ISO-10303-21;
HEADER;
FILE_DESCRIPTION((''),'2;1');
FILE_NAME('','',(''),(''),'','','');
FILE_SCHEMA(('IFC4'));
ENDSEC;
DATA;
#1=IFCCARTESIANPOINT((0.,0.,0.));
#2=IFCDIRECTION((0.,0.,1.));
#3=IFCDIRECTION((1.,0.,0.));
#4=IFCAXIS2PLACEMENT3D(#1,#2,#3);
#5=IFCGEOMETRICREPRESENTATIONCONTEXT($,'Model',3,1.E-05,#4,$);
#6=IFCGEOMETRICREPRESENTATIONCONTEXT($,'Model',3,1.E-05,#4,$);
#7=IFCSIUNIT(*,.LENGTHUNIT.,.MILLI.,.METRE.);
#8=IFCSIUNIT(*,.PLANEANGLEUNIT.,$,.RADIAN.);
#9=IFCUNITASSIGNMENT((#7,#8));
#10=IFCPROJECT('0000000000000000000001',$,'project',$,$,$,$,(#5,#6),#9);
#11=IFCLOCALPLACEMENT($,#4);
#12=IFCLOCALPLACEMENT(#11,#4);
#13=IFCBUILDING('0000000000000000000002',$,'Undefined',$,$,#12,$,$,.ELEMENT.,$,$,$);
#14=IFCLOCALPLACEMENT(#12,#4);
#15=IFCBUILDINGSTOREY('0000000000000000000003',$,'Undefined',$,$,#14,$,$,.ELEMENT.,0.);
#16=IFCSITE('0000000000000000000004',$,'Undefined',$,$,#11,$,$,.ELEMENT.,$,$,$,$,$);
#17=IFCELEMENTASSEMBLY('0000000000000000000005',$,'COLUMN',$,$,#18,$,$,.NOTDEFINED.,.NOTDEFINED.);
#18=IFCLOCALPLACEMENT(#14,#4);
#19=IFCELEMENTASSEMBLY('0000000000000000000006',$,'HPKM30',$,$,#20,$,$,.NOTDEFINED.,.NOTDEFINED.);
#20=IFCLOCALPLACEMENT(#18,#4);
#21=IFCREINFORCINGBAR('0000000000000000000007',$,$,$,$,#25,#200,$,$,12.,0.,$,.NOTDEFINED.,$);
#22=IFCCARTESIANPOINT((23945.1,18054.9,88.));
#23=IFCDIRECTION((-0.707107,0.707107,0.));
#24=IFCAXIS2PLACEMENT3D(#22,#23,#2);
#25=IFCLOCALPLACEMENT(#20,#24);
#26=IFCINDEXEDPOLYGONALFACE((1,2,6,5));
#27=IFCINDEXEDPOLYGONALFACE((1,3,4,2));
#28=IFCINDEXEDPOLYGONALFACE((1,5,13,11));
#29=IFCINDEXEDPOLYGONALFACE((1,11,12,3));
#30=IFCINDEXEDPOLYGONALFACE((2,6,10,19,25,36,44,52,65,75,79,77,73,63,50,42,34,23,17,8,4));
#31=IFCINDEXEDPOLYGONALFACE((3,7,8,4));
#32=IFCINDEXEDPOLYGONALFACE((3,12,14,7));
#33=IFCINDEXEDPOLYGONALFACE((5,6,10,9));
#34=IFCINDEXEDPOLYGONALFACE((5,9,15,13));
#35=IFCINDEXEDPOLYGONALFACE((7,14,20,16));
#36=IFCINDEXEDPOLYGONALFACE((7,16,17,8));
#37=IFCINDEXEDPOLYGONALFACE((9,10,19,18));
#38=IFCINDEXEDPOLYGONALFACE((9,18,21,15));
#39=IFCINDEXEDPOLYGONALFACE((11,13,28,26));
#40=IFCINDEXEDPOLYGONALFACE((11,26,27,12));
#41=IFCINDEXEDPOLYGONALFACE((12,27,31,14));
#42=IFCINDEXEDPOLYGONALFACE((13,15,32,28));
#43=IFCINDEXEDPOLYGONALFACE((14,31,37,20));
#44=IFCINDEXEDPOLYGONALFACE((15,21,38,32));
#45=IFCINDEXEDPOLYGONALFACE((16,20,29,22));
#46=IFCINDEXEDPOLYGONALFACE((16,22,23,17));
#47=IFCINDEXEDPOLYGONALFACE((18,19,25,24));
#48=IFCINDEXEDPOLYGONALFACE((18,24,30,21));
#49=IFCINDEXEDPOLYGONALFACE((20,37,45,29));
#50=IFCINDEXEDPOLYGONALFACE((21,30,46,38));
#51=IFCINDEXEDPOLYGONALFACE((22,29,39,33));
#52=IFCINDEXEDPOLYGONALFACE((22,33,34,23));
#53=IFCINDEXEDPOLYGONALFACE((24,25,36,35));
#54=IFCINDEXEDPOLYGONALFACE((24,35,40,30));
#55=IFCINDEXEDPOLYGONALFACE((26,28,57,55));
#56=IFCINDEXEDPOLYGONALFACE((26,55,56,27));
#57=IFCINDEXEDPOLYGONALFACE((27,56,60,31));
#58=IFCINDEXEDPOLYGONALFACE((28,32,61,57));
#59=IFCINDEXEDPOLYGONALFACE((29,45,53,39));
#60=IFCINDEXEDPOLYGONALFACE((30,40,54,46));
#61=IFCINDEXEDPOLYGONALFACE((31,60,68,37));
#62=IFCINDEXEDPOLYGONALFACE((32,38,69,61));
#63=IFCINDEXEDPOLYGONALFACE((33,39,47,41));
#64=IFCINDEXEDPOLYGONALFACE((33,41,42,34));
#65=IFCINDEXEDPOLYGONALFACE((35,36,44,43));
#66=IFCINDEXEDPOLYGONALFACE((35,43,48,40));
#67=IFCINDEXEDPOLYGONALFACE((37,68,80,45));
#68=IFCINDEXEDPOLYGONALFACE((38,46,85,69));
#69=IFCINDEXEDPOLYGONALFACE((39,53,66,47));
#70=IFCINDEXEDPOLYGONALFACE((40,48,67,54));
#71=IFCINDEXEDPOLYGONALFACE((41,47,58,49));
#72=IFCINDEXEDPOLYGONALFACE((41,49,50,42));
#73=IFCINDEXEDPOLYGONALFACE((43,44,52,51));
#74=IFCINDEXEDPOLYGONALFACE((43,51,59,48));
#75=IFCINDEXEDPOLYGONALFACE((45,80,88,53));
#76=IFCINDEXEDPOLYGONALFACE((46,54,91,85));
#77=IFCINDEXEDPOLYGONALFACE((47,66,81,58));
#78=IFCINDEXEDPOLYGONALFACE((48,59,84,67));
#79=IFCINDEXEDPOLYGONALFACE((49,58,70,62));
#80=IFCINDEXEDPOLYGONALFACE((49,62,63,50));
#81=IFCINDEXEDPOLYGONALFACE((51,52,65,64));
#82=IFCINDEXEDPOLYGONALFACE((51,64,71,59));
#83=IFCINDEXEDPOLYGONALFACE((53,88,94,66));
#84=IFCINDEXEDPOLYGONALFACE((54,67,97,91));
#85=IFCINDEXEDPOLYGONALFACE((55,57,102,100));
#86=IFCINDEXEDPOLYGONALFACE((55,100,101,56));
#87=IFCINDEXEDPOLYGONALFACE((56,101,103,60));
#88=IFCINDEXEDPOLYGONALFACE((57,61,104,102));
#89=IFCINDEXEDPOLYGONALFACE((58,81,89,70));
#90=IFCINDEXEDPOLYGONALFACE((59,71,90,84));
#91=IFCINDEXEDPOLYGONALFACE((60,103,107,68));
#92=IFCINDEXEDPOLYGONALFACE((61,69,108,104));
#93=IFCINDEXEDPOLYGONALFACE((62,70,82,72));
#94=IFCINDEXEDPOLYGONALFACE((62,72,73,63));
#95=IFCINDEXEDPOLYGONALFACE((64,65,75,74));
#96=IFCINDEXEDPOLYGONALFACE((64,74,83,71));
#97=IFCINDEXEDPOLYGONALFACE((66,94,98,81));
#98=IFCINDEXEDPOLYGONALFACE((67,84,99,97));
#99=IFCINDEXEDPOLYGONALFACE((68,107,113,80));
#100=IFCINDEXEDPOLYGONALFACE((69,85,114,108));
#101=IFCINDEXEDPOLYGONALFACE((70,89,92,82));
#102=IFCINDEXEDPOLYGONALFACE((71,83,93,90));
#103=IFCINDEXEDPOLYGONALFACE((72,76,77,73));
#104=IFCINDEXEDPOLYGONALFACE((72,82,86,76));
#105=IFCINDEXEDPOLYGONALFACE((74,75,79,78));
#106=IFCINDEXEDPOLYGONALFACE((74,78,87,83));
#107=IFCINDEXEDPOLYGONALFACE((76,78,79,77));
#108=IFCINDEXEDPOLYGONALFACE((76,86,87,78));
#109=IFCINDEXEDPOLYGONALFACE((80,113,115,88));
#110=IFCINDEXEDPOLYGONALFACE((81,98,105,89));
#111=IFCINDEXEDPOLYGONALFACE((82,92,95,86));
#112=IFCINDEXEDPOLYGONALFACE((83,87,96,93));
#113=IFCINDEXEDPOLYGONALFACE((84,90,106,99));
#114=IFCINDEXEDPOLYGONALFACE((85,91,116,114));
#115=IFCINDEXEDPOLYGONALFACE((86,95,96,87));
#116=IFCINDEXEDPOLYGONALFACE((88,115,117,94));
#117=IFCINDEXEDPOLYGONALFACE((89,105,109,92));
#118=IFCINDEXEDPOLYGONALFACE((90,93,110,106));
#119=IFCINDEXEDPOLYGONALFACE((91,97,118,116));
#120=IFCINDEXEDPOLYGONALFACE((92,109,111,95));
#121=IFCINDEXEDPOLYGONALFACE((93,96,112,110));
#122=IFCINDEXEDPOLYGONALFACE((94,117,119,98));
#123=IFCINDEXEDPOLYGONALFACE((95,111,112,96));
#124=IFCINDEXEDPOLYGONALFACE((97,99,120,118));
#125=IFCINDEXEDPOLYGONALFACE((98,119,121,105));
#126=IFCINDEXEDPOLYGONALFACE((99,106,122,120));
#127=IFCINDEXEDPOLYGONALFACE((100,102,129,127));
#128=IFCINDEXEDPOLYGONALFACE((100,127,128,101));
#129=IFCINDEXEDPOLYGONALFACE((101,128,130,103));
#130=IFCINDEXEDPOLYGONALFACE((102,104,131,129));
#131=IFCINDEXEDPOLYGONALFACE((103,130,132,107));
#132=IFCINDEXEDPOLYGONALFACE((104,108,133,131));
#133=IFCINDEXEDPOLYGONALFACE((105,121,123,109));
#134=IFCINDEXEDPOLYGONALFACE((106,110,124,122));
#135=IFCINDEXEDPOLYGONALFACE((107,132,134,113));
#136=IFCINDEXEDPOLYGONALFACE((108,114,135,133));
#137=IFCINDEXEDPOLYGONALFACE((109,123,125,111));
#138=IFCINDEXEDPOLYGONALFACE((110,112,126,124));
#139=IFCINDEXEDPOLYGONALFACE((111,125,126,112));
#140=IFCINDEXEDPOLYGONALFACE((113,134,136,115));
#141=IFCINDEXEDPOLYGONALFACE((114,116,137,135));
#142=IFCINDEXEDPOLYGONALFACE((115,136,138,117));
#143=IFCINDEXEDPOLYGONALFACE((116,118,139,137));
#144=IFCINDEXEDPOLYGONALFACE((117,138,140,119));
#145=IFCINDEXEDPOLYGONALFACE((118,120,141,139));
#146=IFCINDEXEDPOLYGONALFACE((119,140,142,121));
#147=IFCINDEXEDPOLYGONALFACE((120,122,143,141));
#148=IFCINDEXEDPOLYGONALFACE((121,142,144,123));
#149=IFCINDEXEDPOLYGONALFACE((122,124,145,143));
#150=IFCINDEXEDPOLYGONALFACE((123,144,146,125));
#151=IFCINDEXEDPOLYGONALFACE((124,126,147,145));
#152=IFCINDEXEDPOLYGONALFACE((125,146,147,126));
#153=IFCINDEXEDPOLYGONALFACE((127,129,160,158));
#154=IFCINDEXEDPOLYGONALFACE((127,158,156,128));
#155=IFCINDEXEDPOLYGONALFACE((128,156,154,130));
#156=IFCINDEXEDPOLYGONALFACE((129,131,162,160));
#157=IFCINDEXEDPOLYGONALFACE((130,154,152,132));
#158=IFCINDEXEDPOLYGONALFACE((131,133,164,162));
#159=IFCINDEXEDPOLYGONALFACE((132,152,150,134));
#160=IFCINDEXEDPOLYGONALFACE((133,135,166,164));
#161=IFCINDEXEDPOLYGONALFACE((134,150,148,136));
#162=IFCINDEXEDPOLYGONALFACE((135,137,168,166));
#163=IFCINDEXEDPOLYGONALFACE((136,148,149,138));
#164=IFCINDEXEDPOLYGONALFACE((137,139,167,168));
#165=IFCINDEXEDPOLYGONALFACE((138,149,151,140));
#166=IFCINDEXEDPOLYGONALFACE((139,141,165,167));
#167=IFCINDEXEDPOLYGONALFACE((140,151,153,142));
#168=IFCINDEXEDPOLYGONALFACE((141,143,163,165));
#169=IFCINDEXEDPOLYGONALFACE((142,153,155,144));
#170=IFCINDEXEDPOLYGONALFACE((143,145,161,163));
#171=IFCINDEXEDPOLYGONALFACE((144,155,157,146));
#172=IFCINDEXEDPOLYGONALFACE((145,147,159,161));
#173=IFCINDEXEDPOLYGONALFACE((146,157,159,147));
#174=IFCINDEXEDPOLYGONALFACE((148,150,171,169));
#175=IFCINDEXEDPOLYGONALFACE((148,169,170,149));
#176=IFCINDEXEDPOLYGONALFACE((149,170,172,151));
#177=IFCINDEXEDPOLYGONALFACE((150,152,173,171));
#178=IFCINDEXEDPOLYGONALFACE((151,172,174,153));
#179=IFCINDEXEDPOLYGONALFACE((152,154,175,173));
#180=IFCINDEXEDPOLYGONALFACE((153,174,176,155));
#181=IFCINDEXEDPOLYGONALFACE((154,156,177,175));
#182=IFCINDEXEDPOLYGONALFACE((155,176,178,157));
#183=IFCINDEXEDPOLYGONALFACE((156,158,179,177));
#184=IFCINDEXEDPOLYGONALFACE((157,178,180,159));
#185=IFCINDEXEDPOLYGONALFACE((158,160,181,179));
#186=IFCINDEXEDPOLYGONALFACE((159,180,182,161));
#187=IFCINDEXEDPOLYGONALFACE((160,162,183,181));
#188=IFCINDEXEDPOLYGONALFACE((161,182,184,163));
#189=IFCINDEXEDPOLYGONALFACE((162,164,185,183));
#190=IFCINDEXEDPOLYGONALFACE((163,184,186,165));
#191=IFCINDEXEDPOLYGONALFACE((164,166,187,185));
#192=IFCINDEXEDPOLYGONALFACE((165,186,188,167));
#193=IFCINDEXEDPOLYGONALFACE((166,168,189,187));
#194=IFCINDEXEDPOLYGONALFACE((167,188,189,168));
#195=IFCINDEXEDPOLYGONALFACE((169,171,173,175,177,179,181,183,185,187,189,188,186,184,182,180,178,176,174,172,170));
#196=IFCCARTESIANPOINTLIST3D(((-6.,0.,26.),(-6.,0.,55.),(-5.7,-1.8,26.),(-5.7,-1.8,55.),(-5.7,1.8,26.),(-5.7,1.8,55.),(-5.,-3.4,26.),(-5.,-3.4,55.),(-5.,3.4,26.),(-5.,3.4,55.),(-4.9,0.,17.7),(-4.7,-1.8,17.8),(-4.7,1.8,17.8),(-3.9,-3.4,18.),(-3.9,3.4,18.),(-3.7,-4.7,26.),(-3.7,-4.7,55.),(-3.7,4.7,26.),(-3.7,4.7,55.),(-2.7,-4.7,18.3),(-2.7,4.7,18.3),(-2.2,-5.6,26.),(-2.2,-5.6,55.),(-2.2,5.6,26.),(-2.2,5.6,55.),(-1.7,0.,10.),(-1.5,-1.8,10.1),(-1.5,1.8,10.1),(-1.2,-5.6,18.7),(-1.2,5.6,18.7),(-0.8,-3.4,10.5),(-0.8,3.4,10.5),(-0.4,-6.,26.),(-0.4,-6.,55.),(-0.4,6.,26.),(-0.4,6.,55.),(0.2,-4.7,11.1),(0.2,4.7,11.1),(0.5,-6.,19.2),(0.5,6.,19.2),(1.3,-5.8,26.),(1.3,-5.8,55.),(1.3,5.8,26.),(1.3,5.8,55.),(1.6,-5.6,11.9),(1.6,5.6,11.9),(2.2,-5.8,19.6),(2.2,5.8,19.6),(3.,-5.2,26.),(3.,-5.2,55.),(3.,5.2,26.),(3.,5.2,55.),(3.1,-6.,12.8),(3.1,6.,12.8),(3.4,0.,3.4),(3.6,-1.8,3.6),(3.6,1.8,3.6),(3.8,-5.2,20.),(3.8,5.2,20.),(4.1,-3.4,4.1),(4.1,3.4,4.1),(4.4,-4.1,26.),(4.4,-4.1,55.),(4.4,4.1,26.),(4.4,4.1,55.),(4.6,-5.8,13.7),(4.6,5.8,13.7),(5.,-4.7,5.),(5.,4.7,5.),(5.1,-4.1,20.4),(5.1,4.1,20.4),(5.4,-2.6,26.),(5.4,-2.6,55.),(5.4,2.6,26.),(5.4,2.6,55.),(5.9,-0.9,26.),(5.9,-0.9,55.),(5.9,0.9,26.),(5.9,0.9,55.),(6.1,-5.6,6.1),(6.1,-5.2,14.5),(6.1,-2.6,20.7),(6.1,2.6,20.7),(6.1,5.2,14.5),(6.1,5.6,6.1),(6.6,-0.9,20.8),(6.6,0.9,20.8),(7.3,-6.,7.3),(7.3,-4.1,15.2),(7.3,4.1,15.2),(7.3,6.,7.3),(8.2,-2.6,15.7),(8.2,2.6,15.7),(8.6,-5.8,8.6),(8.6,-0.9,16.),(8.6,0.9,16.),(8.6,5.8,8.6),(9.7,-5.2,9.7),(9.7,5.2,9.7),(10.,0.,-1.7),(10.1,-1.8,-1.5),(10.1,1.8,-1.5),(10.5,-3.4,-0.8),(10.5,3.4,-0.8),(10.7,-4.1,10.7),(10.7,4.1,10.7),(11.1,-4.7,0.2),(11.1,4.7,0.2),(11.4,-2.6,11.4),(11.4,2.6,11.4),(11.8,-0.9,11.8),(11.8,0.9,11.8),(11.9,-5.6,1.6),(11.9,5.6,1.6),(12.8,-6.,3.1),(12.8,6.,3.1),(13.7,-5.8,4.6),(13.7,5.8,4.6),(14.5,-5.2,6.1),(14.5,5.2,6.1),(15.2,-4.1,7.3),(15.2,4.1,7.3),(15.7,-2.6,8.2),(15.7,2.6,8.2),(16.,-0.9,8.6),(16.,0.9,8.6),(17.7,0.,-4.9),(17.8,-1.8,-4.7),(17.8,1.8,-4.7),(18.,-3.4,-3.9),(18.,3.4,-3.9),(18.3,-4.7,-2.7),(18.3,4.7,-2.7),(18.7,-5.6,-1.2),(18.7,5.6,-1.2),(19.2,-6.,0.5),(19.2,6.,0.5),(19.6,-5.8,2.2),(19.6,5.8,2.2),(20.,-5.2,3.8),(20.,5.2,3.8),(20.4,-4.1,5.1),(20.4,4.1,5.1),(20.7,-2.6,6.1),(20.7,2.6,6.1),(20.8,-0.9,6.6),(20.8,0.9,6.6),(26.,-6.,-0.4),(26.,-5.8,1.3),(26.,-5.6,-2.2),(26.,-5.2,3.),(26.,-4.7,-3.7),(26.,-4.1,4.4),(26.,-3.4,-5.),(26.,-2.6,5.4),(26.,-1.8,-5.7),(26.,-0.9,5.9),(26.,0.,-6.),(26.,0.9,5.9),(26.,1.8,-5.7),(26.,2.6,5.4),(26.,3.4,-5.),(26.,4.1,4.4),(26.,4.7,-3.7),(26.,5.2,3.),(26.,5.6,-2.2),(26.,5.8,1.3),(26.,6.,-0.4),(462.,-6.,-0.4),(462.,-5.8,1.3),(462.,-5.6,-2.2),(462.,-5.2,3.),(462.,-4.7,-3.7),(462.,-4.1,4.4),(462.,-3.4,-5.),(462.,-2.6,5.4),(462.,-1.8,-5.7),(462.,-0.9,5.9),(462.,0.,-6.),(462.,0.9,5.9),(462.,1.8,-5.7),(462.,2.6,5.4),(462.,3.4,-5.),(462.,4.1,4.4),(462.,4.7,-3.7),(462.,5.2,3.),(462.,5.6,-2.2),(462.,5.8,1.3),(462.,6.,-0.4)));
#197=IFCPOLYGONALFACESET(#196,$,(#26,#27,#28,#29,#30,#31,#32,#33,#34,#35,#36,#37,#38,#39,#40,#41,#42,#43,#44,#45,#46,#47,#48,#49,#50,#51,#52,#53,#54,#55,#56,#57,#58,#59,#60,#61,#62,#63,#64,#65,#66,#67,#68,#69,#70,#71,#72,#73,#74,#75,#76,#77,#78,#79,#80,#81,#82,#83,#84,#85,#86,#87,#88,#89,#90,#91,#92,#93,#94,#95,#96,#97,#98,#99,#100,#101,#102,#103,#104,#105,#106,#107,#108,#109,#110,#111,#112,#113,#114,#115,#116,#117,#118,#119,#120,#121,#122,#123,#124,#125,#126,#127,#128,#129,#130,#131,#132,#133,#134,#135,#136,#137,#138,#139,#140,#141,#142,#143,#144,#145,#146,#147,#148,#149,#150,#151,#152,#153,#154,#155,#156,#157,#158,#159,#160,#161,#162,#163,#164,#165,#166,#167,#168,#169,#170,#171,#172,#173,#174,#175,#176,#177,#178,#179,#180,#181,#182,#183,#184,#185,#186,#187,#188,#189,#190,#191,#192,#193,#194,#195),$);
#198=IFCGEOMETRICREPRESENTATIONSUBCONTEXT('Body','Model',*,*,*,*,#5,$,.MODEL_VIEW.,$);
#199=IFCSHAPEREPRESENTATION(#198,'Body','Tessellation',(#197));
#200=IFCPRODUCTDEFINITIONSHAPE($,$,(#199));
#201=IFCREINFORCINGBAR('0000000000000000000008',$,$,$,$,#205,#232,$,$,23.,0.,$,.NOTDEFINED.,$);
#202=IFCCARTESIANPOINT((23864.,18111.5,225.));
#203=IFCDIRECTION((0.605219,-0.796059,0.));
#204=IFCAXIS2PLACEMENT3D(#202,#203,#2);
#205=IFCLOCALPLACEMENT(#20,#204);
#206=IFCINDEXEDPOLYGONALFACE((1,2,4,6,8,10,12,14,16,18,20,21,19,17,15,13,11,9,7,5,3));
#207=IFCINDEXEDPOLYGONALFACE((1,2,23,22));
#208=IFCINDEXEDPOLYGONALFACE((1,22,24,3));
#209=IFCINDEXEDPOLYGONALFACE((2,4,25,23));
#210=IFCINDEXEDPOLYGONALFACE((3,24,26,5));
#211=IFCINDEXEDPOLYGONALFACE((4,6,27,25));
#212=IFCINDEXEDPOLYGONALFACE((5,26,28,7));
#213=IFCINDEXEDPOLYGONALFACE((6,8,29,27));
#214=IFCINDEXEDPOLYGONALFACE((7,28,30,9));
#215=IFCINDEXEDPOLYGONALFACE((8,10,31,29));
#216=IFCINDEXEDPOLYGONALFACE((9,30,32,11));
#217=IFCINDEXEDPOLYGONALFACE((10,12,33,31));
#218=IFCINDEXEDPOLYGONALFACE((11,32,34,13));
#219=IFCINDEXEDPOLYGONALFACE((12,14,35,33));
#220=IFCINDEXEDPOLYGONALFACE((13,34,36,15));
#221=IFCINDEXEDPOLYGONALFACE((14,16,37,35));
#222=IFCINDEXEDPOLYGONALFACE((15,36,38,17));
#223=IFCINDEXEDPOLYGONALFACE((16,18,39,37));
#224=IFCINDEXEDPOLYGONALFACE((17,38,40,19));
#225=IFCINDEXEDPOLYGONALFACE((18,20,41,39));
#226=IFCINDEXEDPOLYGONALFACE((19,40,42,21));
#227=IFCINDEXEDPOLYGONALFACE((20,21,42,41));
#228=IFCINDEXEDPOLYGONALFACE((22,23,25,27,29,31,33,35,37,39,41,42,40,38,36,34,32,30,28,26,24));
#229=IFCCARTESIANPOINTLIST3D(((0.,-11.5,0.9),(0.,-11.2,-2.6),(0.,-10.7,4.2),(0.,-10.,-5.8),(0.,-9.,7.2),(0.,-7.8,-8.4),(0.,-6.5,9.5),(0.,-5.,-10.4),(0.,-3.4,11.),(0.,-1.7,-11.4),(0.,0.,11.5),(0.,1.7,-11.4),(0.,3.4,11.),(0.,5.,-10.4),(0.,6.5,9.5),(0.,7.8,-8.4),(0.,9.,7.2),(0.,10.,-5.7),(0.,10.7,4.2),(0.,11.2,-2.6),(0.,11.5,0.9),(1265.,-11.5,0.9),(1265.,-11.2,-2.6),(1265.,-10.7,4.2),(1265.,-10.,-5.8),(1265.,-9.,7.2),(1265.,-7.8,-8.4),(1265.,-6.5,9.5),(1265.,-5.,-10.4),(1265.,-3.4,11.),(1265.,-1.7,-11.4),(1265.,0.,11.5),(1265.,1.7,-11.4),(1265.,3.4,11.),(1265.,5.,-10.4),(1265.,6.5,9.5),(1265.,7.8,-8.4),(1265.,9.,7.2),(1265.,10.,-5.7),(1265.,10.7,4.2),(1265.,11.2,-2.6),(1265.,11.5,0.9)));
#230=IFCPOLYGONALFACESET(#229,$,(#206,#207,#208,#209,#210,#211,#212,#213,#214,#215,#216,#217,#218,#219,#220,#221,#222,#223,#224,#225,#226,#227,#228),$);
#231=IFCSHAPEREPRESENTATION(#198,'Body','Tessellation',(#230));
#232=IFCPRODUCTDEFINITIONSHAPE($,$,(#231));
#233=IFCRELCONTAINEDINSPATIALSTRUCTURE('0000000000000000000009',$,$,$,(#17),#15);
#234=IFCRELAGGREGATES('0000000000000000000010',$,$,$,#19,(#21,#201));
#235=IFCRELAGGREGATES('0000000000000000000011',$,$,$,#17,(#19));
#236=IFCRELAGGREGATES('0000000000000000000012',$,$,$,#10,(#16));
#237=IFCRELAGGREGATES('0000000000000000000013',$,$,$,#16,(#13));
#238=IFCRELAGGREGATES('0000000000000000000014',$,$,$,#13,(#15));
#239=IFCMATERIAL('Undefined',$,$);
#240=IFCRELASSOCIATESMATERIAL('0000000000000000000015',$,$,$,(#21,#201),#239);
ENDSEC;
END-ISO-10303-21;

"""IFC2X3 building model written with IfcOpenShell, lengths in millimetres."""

from ifc_helpers import new_model, entity, si_unit, frame, origin_with_axes, place, context, subcontext, project, spatial, source, transform, mapped, material, element, aggregate, save


model = new_model("IFC2X3")

# Units and contexts
model_context_1 = context("Model", 3, precision=1e-05, world=origin_with_axes())
model_context_2 = context("Model", 3, precision=1e-05, world=origin_with_axes())
body_context = subcontext(model_context_1, "Body", "Model", "MODEL_VIEW")
ifc_project = project(units=[si_unit("LENGTHUNIT", "METRE", prefix="MILLI"), si_unit("PLANEANGLEUNIT", "RADIAN")], contexts=[model_context_1, model_context_2])

# Site, building, storey
site_placement = place(None, origin_with_axes())
site = spatial("IfcSite", under=ifc_project, at=site_placement, Name="Undefined", CompositionType="ELEMENT")
building_placement = place(site_placement, origin_with_axes())
building = spatial("IfcBuilding", under=site, at=building_placement, Name="Undefined", CompositionType="ELEMENT")
storey_placement = place(building_placement, origin_with_axes())
storey = spatial("IfcBuildingStorey", under=building, at=storey_placement, Name="Undefined", CompositionType="ELEMENT", Elevation=0.0)

# Element assemblies
assembly_1_placement = place(storey_placement, origin_with_axes())
assembly_1 = element("IfcElementAssembly", 1, at=assembly_1_placement, inside=storey, Name="COLUMN", AssemblyPlace="NOTDEFINED", PredefinedType="NOTDEFINED")
assembly_2_placement = place(assembly_1_placement, origin_with_axes())
assembly_2 = element("IfcElementAssembly", 2, at=assembly_2_placement, Name="HPKM30", AssemblyPlace="NOTDEFINED", PredefinedType="NOTDEFINED")
ifc_material_1 = material(Name="Undefined")

# Reinforcing bars
shared_shape_1 = source(origin_with_axes(), body_context, "Body", "AdvancedSweptSolid", [
    entity("IfcSweptDiskSolid", entity("IfcCompositeCurve", [entity("IfcCompositeCurveSegment", "CONTINUOUS", True, entity("IfcTrimmedCurve", entity("IfcLine", entity("IfcCartesianPoint", [0.0, 0.0, 0.0]), entity("IfcVector", entity("IfcDirection", [0.0, 0.0, -1.0]), 1.0)), [entity("IfcParameterValue", 0.0)], [entity("IfcParameterValue", 29.0)], True, "PARAMETER")), entity("IfcCompositeCurveSegment", "CONTINUOUS", True, entity("IfcTrimmedCurve", entity("IfcCircle", entity("IfcAxis2Placement3D", entity("IfcCartesianPoint", [26.0, 0.0, -29.0]), entity("IfcDirection", [0.0, -1.0, 0.0]), entity("IfcDirection", [-1.0, 0.0, 0.0])), 26.0), [entity("IfcParameterValue", 0.0)], [entity("IfcParameterValue", 1.570796)], True, "PARAMETER")), entity("IfcCompositeCurveSegment", "DISCONTINUOUS", True, entity("IfcTrimmedCurve", entity("IfcLine", entity("IfcCartesianPoint", [26.0, 0.0, -55.0]), entity("IfcVector", entity("IfcDirection", [1.0, 0.0, 0.0]), 1.0)), [entity("IfcParameterValue", 0.0)], [entity("IfcParameterValue", 436.0)], True, "PARAMETER"))], False), 6.0, None, 0.0, 466.6),
])
reinforcing_bar_1_placement = place(assembly_2_placement, frame((23945.1, 18054.9, 88.0), z_axis=(-0.707107, 0.707107, 0.0), x_axis=(0.0, 0.0, 1.0)))
reinforcing_bar_1 = element("IfcReinforcingBar", 3, at=reinforcing_bar_1_placement, material=ifc_material_1, BarRole="NOTDEFINED", CrossSectionArea=0.0, NominalDiameter=12.0, context=body_context, shape_type="MappedRepresentation", body=[
    mapped(shared_shape_1, transform((0.0, 0.0, 55.0))),
])
shared_shape_2 = source(origin_with_axes(), body_context, "Body", "AdvancedSweptSolid", [
    entity("IfcSweptDiskSolid", entity("IfcTrimmedCurve", entity("IfcLine", entity("IfcCartesianPoint", [0.0, 0.0, 0.0]), entity("IfcVector", entity("IfcDirection", [1.0, 0.0, 0.0]), 1.0)), [entity("IfcParameterValue", 0.0)], [entity("IfcParameterValue", 1265.0)], True, "PARAMETER"), 11.5, None, 0.0, 1265.0),
])
reinforcing_bar_2_placement = place(assembly_2_placement, frame((23864.0, 18111.5, 225.0), z_axis=(0.605219, -0.796059, 0.0), x_axis=(0.0, 0.0, 1.0)))
reinforcing_bar_2 = element("IfcReinforcingBar", 4, at=reinforcing_bar_2_placement, material=ifc_material_1, BarRole="NOTDEFINED", CrossSectionArea=0.0, NominalDiameter=23.0, context=body_context, shape_type="MappedRepresentation", body=[
    mapped(shared_shape_2, transform((0.0, 0.0, 0.0))),
])
aggregate(assembly_2, [reinforcing_bar_1, reinforcing_bar_2])
aggregate(assembly_1, [assembly_2])

save(model, "model.ifc")
